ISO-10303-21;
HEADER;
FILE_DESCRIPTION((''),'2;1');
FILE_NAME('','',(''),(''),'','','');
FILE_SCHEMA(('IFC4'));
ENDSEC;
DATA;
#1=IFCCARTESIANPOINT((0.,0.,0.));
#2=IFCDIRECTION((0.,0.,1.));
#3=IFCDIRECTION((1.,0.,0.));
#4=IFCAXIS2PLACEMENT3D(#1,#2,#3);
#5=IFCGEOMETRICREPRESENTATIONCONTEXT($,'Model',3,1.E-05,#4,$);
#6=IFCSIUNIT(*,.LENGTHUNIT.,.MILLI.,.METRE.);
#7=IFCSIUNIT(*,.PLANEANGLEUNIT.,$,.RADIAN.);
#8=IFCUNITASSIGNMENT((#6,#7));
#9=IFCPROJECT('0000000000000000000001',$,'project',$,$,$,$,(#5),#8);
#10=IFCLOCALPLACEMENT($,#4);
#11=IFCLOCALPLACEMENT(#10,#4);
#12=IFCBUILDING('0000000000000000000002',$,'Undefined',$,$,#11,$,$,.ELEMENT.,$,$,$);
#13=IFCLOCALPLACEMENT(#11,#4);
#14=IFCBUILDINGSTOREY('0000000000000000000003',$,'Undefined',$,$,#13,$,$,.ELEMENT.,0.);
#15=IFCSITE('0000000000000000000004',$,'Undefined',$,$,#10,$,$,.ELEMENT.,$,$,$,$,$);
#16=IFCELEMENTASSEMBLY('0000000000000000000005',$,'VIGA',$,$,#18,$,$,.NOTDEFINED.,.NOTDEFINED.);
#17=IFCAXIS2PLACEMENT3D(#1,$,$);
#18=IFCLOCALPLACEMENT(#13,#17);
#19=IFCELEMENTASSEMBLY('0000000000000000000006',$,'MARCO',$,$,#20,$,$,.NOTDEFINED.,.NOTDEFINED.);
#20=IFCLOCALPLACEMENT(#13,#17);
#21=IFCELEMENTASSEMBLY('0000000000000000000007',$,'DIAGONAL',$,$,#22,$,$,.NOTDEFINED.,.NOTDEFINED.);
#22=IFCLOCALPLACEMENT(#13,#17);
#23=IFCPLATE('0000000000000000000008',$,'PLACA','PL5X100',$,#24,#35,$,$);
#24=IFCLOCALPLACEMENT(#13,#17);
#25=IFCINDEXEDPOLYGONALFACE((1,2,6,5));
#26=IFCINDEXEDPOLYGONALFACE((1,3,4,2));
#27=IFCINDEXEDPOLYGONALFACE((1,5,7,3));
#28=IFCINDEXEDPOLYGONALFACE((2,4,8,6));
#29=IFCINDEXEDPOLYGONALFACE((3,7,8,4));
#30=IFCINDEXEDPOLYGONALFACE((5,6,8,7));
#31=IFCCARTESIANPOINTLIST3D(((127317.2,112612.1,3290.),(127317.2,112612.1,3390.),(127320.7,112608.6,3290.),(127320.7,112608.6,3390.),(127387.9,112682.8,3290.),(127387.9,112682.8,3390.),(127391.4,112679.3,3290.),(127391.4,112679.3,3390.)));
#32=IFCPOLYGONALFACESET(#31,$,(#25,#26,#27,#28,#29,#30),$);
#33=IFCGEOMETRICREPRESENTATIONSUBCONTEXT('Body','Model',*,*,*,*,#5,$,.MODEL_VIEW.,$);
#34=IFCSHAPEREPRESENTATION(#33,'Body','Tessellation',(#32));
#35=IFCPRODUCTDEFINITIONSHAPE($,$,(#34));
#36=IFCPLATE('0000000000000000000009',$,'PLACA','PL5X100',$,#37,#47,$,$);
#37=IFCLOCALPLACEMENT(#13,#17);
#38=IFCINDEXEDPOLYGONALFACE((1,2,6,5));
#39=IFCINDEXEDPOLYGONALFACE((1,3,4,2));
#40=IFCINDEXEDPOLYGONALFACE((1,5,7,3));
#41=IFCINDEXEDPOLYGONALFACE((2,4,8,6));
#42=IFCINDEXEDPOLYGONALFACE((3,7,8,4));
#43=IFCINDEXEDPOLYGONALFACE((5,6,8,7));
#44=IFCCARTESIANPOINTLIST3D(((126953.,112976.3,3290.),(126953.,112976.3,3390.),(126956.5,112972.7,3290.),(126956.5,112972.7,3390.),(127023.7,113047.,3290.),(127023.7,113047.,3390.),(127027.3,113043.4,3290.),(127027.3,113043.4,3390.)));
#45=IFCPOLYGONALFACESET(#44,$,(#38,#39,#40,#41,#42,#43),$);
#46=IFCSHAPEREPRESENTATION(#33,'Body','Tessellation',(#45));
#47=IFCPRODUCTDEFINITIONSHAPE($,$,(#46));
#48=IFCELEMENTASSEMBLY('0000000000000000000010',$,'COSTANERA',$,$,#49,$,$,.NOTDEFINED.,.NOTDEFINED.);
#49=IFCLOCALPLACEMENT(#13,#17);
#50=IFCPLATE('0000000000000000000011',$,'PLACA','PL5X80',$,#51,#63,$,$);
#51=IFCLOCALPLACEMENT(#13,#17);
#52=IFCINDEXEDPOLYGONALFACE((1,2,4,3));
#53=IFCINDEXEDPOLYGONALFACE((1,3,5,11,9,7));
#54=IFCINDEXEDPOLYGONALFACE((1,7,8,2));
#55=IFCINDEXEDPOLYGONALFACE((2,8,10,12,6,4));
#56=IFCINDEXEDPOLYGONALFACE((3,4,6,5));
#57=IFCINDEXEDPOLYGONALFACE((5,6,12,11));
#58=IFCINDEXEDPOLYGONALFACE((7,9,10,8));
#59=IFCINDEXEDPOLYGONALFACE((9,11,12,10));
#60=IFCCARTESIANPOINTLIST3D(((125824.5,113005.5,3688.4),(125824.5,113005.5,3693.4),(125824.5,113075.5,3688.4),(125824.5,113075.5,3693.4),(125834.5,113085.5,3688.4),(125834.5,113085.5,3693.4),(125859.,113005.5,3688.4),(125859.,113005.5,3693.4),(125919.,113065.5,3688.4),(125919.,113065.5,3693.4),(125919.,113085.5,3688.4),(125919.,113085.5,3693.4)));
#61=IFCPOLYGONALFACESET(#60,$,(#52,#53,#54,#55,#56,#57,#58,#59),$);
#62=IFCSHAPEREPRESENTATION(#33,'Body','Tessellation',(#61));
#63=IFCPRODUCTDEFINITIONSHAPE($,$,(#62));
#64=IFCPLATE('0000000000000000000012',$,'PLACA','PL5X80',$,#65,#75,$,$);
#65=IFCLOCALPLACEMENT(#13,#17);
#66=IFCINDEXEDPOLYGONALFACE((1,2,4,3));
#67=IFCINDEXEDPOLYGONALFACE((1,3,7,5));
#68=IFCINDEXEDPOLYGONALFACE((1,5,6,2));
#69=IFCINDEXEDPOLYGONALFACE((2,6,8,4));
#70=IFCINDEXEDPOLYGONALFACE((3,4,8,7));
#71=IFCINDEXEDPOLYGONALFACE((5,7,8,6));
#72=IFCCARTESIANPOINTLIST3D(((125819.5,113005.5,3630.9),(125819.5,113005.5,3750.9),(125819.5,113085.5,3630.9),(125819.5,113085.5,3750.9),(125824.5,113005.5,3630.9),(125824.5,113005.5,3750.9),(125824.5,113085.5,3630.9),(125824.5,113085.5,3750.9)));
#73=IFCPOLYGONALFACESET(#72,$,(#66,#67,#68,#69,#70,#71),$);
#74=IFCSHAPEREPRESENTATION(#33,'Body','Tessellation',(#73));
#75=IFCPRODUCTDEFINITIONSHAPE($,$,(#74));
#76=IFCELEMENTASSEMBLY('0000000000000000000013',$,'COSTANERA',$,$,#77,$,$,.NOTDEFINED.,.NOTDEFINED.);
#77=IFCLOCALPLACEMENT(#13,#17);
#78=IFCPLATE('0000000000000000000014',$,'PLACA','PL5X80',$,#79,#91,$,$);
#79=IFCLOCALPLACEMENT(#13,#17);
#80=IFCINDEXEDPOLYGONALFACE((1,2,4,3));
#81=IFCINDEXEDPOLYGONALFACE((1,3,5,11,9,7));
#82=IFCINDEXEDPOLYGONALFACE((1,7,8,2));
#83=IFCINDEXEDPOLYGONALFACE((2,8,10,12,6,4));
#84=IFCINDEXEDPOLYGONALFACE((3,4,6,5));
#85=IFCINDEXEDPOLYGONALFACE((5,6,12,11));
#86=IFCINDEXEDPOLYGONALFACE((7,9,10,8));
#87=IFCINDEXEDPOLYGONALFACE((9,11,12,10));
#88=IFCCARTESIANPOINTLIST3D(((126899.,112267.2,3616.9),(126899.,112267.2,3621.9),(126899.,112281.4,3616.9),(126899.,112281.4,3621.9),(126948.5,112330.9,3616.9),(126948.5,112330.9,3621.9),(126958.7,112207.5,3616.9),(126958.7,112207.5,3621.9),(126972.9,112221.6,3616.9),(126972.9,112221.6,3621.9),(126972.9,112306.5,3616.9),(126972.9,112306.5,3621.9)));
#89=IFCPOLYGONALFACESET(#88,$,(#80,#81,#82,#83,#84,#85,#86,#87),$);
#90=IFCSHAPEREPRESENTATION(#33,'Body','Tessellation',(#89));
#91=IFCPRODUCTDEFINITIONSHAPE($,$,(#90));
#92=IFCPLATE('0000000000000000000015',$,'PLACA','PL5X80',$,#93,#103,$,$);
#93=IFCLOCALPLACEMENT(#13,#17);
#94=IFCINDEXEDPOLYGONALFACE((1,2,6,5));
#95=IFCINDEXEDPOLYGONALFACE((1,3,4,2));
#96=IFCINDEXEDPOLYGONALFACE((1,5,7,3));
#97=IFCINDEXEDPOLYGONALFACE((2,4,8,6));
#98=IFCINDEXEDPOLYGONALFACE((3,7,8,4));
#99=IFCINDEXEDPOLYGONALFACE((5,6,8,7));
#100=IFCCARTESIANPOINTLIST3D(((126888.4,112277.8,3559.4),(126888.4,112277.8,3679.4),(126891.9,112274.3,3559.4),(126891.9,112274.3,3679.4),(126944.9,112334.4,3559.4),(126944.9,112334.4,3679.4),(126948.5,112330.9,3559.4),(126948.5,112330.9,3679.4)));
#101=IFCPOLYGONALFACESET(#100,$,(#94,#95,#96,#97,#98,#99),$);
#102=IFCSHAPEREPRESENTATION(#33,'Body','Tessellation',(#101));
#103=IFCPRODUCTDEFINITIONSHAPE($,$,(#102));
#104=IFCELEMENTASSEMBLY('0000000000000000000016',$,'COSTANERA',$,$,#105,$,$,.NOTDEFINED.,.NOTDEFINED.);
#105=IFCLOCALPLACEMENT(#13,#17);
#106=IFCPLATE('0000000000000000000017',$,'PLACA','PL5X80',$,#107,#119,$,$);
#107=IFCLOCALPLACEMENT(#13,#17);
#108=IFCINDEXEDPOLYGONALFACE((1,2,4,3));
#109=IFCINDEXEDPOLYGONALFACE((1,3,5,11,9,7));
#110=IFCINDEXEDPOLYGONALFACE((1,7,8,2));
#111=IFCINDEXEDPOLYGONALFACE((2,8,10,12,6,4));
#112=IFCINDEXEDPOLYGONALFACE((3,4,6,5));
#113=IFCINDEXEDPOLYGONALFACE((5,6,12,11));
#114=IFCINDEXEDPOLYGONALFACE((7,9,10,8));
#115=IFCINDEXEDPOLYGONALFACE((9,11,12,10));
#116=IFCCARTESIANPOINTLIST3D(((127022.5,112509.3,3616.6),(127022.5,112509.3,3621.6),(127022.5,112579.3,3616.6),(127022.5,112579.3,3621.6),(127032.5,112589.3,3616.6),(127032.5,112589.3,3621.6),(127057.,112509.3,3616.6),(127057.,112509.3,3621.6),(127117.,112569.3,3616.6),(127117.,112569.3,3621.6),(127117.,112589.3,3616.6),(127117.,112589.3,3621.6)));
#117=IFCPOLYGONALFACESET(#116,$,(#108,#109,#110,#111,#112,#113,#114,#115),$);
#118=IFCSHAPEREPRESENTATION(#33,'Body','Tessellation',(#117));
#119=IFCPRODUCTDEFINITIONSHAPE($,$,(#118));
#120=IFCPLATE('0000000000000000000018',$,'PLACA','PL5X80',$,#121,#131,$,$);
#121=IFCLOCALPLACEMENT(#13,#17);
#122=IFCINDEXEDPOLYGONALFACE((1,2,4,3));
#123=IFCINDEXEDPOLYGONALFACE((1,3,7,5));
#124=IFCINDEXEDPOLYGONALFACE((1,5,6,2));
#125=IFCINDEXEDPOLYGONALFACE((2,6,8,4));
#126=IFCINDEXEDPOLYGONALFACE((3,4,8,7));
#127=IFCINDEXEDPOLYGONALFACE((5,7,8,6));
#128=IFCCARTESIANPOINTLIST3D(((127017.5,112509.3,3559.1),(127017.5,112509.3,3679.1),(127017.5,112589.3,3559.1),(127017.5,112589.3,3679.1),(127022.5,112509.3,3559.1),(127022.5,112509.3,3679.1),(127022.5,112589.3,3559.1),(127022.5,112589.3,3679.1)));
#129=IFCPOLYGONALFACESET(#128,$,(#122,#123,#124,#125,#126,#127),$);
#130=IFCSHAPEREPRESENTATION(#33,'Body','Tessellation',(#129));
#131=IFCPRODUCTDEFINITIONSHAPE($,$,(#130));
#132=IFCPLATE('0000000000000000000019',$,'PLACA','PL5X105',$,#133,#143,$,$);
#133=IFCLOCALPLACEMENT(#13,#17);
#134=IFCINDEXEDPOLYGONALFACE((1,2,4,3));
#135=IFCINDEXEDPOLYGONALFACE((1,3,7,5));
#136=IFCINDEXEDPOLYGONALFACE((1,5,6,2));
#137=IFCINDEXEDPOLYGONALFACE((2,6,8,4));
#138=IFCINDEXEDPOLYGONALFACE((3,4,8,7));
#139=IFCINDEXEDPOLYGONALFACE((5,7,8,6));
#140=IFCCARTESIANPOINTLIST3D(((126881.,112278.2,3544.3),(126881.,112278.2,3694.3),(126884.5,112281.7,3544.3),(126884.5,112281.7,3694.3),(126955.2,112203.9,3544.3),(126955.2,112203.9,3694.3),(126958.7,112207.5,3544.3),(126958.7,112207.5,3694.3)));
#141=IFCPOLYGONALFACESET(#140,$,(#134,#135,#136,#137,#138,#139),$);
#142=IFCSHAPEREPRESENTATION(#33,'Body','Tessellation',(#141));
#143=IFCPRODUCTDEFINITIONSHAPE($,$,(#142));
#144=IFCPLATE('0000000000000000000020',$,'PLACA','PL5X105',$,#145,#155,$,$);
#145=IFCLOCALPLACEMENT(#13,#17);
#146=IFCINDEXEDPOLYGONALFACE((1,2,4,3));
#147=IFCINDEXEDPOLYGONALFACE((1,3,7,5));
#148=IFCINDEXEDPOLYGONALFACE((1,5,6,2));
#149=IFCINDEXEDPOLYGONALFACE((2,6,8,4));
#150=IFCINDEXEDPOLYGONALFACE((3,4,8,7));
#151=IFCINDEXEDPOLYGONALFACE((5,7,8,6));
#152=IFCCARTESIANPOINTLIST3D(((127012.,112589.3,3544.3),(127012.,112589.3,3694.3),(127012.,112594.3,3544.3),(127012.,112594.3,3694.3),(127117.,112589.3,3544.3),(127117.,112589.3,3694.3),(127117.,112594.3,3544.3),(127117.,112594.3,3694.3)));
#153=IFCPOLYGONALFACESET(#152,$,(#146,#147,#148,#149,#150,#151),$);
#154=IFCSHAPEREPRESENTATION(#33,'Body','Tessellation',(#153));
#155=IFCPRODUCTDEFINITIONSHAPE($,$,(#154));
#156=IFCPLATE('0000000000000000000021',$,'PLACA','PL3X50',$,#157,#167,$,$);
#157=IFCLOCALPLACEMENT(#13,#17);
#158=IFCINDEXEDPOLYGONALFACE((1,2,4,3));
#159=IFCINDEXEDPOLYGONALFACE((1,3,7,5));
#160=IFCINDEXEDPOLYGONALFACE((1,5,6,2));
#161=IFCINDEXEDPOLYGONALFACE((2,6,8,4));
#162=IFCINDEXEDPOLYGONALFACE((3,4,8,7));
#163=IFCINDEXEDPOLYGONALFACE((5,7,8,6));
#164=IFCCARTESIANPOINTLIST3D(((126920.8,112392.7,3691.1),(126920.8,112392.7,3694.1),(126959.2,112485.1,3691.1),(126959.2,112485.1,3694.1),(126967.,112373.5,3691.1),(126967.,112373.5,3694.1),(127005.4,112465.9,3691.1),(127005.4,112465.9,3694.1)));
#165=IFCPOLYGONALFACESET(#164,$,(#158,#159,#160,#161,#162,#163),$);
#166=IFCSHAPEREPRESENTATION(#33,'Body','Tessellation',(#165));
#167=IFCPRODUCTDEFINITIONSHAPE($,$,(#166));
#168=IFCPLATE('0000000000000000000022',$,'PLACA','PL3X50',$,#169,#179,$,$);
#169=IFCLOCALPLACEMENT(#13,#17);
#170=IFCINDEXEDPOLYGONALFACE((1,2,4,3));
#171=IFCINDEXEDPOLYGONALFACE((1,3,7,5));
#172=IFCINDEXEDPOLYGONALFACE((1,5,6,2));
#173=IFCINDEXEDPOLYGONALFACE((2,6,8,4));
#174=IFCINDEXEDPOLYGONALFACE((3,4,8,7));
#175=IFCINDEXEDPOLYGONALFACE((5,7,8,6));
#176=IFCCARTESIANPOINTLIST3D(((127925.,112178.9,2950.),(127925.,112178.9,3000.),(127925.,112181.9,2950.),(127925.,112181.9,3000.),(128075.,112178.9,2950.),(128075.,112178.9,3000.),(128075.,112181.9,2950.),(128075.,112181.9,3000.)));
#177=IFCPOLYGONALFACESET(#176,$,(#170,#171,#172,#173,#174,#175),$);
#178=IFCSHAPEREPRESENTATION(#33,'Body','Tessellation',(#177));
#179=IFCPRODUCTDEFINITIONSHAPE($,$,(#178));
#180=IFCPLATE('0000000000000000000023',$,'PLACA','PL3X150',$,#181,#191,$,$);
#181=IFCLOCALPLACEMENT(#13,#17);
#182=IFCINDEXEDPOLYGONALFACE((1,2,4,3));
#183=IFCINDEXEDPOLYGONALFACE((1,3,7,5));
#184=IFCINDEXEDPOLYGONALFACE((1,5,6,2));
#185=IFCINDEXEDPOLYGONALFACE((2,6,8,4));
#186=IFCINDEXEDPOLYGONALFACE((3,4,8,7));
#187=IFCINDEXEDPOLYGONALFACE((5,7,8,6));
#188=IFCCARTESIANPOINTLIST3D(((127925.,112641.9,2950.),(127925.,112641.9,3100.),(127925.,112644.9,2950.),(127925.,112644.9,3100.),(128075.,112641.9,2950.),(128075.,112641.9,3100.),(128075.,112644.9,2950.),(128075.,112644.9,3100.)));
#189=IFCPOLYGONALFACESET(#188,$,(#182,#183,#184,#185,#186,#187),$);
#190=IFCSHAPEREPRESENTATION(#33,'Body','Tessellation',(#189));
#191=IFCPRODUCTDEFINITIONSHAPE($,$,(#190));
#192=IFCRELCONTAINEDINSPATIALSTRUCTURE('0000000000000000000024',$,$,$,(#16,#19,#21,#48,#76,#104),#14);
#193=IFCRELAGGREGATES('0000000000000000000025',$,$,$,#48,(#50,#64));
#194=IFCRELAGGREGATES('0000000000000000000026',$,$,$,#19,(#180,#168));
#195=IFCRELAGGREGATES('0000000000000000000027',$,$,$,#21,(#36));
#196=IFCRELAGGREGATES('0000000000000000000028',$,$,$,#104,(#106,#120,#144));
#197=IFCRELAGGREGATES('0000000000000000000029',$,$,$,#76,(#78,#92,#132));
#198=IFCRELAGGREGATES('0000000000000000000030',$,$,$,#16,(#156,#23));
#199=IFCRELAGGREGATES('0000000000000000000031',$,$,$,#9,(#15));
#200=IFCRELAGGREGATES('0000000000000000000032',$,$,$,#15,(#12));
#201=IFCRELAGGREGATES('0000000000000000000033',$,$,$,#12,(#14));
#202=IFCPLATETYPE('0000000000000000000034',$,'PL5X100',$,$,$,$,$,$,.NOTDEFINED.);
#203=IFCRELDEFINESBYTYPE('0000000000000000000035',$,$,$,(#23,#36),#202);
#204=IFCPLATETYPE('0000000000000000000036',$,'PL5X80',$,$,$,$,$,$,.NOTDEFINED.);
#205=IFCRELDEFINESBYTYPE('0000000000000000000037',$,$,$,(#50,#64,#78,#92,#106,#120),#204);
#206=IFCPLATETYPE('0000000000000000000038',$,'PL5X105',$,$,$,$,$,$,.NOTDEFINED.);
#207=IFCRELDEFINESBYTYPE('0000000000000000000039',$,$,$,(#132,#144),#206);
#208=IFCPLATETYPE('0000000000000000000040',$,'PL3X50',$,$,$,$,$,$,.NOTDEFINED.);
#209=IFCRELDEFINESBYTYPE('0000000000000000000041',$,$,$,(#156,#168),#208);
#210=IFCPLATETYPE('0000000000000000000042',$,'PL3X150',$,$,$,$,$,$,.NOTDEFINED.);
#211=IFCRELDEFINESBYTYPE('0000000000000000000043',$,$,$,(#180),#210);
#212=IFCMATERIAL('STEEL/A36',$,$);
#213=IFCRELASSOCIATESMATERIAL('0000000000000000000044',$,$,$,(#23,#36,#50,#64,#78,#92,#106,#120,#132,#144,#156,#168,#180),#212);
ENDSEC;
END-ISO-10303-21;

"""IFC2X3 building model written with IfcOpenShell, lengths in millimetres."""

from ifc_helpers import new_model, si_unit, frame, origin_with_axes, place, context, subcontext, project, spatial, polyline, outline, extrude, material, type_object, element, aggregate, save


model = new_model("IFC2X3")

# Units and contexts
model_context = context("Model", 3, precision=1e-05, world=origin_with_axes())
body_context = subcontext(model_context, "Body", "Model", "MODEL_VIEW")
ifc_project = project(units=[si_unit("LENGTHUNIT", "METRE", prefix="MILLI"), si_unit("PLANEANGLEUNIT", "RADIAN")], contexts=[model_context])

# Site, building, storey
site_placement = place(None, origin_with_axes())
site = spatial("IfcSite", under=ifc_project, at=site_placement, Name="Undefined", CompositionType="ELEMENT")
building_placement = place(site_placement, origin_with_axes())
building = spatial("IfcBuilding", under=site, at=building_placement, Name="Undefined", CompositionType="ELEMENT")
storey_placement = place(building_placement, origin_with_axes())
storey = spatial("IfcBuildingStorey", under=building, at=storey_placement, Name="Undefined", CompositionType="ELEMENT", Elevation=0.0)

# Element assembly
assembly_1_placement = place(storey_placement, origin_with_axes())
assembly_1 = element("IfcElementAssembly", 1, at=assembly_1_placement, inside=storey, Name="VIGA", AssemblyPlace="NOTDEFINED", PredefinedType="NOTDEFINED")
ifc_material_1 = material(Name="STEEL/A36")

# Element assembly
assembly_2_placement = place(storey_placement, origin_with_axes())
assembly_2 = element("IfcElementAssembly", 2, at=assembly_2_placement, inside=storey, Name="MARCO", AssemblyPlace="NOTDEFINED", PredefinedType="NOTDEFINED")

# Element assembly
assembly_3_placement = place(storey_placement, origin_with_axes())
assembly_3 = element("IfcElementAssembly", 3, at=assembly_3_placement, inside=storey, Name="DIAGONAL", AssemblyPlace="NOTDEFINED", PredefinedType="NOTDEFINED")

# Plates
plate_type_1 = type_object("IfcPlateType", Name="PL5X100", PredefinedType="NOTDEFINED")
plate_1_placement = place(assembly_1_placement, frame((127354.3, 112645.7, 3390.0), z_axis=(0.707107, -0.707107, 0.0), x_axis=(0.0, 0.0, -1.0)))
plate_1 = element("IfcPlate", 4, at=plate_1_placement, type_object=plate_type_1, material=ifc_material_1, Name="PLACA", Description="PL5X100", context=body_context, shape_type="SweptSolid", body=[
    extrude(outline(polyline([(0.0, -50.0), (0.0, 50.0), (100.0, 50.0), (100.0, -50.0), (0.0, -50.0)])), frame((0.0, 0.0, -2.5), z_axis=(0.0, 0.0, 1.0), x_axis=(1.0, 0.0, 0.0)), (0.0, 0.0, 1.0), 5.0),
])
plate_2_placement = place(assembly_3_placement, frame((126990.1, 113009.9, 3390.0), z_axis=(-0.707107, 0.707107, 0.0), x_axis=(0.0, 0.0, -1.0)))
plate_2 = element("IfcPlate", 5, at=plate_2_placement, type_object=plate_type_1, material=ifc_material_1, Name="PLACA", Description="PL5X100", context=body_context, shape_type="SweptSolid", body=[
    extrude(outline(polyline([(0.0, -50.0), (0.0, 50.0), (100.0, 50.0), (100.0, -50.0), (0.0, -50.0)])), frame((0.0, 0.0, -2.5), z_axis=(0.0, 0.0, 1.0), x_axis=(1.0, 0.0, 0.0)), (0.0, 0.0, 1.0), 5.0),
])

# Element assemblies, plates
assembly_4_placement = place(storey_placement, origin_with_axes())
assembly_4 = element("IfcElementAssembly", 6, at=assembly_4_placement, inside=storey, Name="COSTANERA", AssemblyPlace="NOTDEFINED", PredefinedType="NOTDEFINED")
plate_type_2 = type_object("IfcPlateType", Name="PL5X80", PredefinedType="NOTDEFINED")
plate_3_placement = place(assembly_4_placement, frame((125824.5, 113005.5, 3690.9), z_axis=(0.0, 0.0, -1.0), x_axis=(0.000007, 1.0, 0.0)))
plate_3 = element("IfcPlate", 7, at=plate_3_placement, type_object=plate_type_2, material=ifc_material_1, Name="PLACA", Description="PL5X80", context=body_context, shape_type="SweptSolid", body=[
    extrude(outline(polyline([(0.0, 0.0), (70.0, 0.0), (80.0, 10.0), (80.0, 94.5), (60.0, 94.5), (0.0, 34.5), (0.0, 0.0)])), frame((0.0, 0.0, -2.5), z_axis=(0.0, 0.0, 1.0), x_axis=(1.0, 0.0, 0.0)), (0.0, 0.0, 1.0), 5.0),
])
plate_4_placement = place(assembly_4_placement, frame((125822.0, 113005.5, 3630.9), z_axis=(1.0, -0.000007, 0.0), x_axis=(0.000007, 1.0, 0.0)))
plate_4 = element("IfcPlate", 8, at=plate_4_placement, type_object=plate_type_2, material=ifc_material_1, Name="PLACA", Description="PL5X80", context=body_context, shape_type="SweptSolid", body=[
    extrude(outline(polyline([(0.0, 0.0), (80.0, 0.0), (80.0, 120.0), (0.0, 120.0), (0.0, 0.0)])), frame((0.0, 0.0, -2.5), z_axis=(0.0, 0.0, 1.0), x_axis=(1.0, 0.0, 0.0)), (0.0, 0.0, 1.0), 5.0),
])
aggregate(assembly_4, [plate_3, plate_4])
assembly_5_placement = place(storey_placement, origin_with_axes())
assembly_5 = element("IfcElementAssembly", 9, at=assembly_5_placement, inside=storey, Name="COSTANERA", AssemblyPlace="NOTDEFINED", PredefinedType="NOTDEFINED")
plate_5_placement = place(assembly_5_placement, frame((126948.5, 112330.9, 3619.4), z_axis=(0.0, 0.0, 1.0), x_axis=(-0.70711, -0.707104, 0.0)))
plate_5 = element("IfcPlate", 10, at=plate_5_placement, type_object=plate_type_2, material=ifc_material_1, Name="PLACA", Description="PL5X80", context=body_context, shape_type="SweptSolid", body=[
    extrude(outline(polyline([(0.0, 0.0), (70.0, 0.0), (80.0, 10.0), (80.0, 94.5), (60.0, 94.5), (0.0, 34.5), (0.0, 0.0)])), frame((0.0, 0.0, -2.5), z_axis=(0.0, 0.0, 1.0), x_axis=(1.0, 0.0, 0.0)), (0.0, 0.0, 1.0), 5.0),
])
plate_6_placement = place(assembly_5_placement, frame((126946.7, 112332.6, 3679.4), z_axis=(0.707104, -0.70711, 0.0), x_axis=(-0.70711, -0.707104, 0.0)))
plate_6 = element("IfcPlate", 11, at=plate_6_placement, type_object=plate_type_2, material=ifc_material_1, Name="PLACA", Description="PL5X80", context=body_context, shape_type="SweptSolid", body=[
    extrude(outline(polyline([(0.0, 0.0), (80.0, 0.0), (80.0, 120.0), (0.0, 120.0), (0.0, 0.0)])), frame((0.0, 0.0, -2.5), z_axis=(0.0, 0.0, 1.0), x_axis=(1.0, 0.0, 0.0)), (0.0, 0.0, 1.0), 5.0),
])
assembly_6_placement = place(storey_placement, origin_with_axes())
assembly_6 = element("IfcElementAssembly", 12, at=assembly_6_placement, inside=storey, Name="COSTANERA", AssemblyPlace="NOTDEFINED", PredefinedType="NOTDEFINED")
plate_7_placement = place(assembly_6_placement, frame((127022.5, 112509.3, 3619.1), z_axis=(0.0, 0.0, -1.0), x_axis=(0.000007, 1.0, 0.0)))
plate_7 = element("IfcPlate", 13, at=plate_7_placement, type_object=plate_type_2, material=ifc_material_1, Name="PLACA", Description="PL5X80", context=body_context, shape_type="SweptSolid", body=[
    extrude(outline(polyline([(0.0, 0.0), (70.0, 0.0), (80.0, 10.0), (80.0, 94.5), (60.0, 94.5), (0.0, 34.5), (0.0, 0.0)])), frame((0.0, 0.0, -2.5), z_axis=(0.0, 0.0, 1.0), x_axis=(1.0, 0.0, 0.0)), (0.0, 0.0, 1.0), 5.0),
])
plate_8_placement = place(assembly_6_placement, frame((127020.0, 112509.3, 3559.1), z_axis=(1.0, -0.000007, 0.0), x_axis=(0.000007, 1.0, 0.0)))
plate_8 = element("IfcPlate", 14, at=plate_8_placement, type_object=plate_type_2, material=ifc_material_1, Name="PLACA", Description="PL5X80", context=body_context, shape_type="SweptSolid", body=[
    extrude(outline(polyline([(0.0, 0.0), (80.0, 0.0), (80.0, 120.0), (0.0, 120.0), (0.0, 0.0)])), frame((0.0, 0.0, -2.5), z_axis=(0.0, 0.0, 1.0), x_axis=(1.0, 0.0, 0.0)), (0.0, 0.0, 1.0), 5.0),
])

# Plates
plate_type_3 = type_object("IfcPlateType", Name="PL5X105", PredefinedType="NOTDEFINED")
plate_9_placement = place(assembly_5_placement, frame((126882.7, 112279.9, 3544.3), z_axis=(-0.70711, -0.707104, 0.0), x_axis=(0.707104, -0.70711, 0.0)))
plate_9 = element("IfcPlate", 15, at=plate_9_placement, type_object=plate_type_3, material=ifc_material_1, Name="PLACA", Description="PL5X105", context=body_context, shape_type="SweptSolid", body=[
    extrude(outline(polyline([(0.0, 0.0), (105.0, 0.0), (105.0, 150.0), (0.0, 150.0), (0.0, 0.0)])), frame((0.0, 0.0, -2.5), z_axis=(0.0, 0.0, 1.0), x_axis=(1.0, 0.0, 0.0)), (0.0, 0.0, 1.0), 5.0),
])
plate_10_placement = place(assembly_6_placement, frame((127012.0, 112591.8, 3694.3), z_axis=(0.000007, 1.0, 0.0), x_axis=(1.0, -0.000007, 0.0)))
plate_10 = element("IfcPlate", 16, at=plate_10_placement, type_object=plate_type_3, material=ifc_material_1, Name="PLACA", Description="PL5X105", context=body_context, shape_type="SweptSolid", body=[
    extrude(outline(polyline([(0.0, 0.0), (105.0, 0.0), (105.0, 150.0), (0.0, 150.0), (0.0, 0.0)])), frame((0.0, 0.0, -2.5), z_axis=(0.0, 0.0, 1.0), x_axis=(1.0, 0.0, 0.0)), (0.0, 0.0, 1.0), 5.0),
])
plate_type_4 = type_object("IfcPlateType", Name="PL3X50", PredefinedType="NOTDEFINED")
plate_11_placement = place(assembly_1_placement, frame((127005.4, 112465.9, 3692.6), z_axis=(0.0, 0.0, 1.0), x_axis=(-0.923347, 0.383967, 0.0)))
plate_11 = element("IfcPlate", 17, at=plate_11_placement, type_object=plate_type_4, material=ifc_material_1, Name="PLACA", Description="PL3X50", context=body_context, shape_type="SweptSolid", body=[
    extrude(outline(polyline([(0.0, 0.0), (50.0, 0.0), (50.0, 100.0), (0.0, 100.0), (0.0, 0.0)])), frame((0.0, 0.0, -1.5), z_axis=(0.0, 0.0, 1.0), x_axis=(1.0, 0.0, 0.0)), (0.0, 0.0, 1.0), 3.0),
])
plate_12_placement = place(assembly_2_placement, frame((127925.0, 112180.4, 2950.0), z_axis=(0.0, 1.0, 0.0), x_axis=(0.0, 0.0, 1.0)))
plate_12 = element("IfcPlate", 18, at=plate_12_placement, type_object=plate_type_4, material=ifc_material_1, Name="PLACA", Description="PL3X50", context=body_context, shape_type="SweptSolid", body=[
    extrude(outline(polyline([(0.0, 0.0), (50.0, 0.0), (50.0, 150.0), (0.0, 150.0), (0.0, 0.0)])), frame((0.0, 0.0, -1.5), z_axis=(0.0, 0.0, 1.0), x_axis=(1.0, 0.0, 0.0)), (0.0, 0.0, 1.0), 3.0),
])
plate_type_5 = type_object("IfcPlateType", Name="PL3X150", PredefinedType="NOTDEFINED")
plate_13_placement = place(assembly_2_placement, frame((127925.0, 112643.4, 3100.0), z_axis=(0.0, 1.0, 0.0), x_axis=(1.0, 0.0, 0.0)))
plate_13 = element("IfcPlate", 19, at=plate_13_placement, type_object=plate_type_5, material=ifc_material_1, Name="PLACA", Description="PL3X150", context=body_context, shape_type="SweptSolid", body=[
    extrude(outline(polyline([(0.0, 0.0), (150.0, 0.0), (150.0, 150.0), (0.0, 150.0), (0.0, 0.0)])), frame((0.0, 0.0, -1.5), z_axis=(0.0, 0.0, 1.0), x_axis=(1.0, 0.0, 0.0)), (0.0, 0.0, 1.0), 3.0),
])
aggregate(assembly_2, [plate_13, plate_12])

aggregate(assembly_3, [plate_2])

aggregate(assembly_6, [plate_7, plate_8, plate_10])
aggregate(assembly_5, [plate_5, plate_6, plate_9])
aggregate(assembly_1, [plate_11, plate_1])

save(model, "model.ifc")
